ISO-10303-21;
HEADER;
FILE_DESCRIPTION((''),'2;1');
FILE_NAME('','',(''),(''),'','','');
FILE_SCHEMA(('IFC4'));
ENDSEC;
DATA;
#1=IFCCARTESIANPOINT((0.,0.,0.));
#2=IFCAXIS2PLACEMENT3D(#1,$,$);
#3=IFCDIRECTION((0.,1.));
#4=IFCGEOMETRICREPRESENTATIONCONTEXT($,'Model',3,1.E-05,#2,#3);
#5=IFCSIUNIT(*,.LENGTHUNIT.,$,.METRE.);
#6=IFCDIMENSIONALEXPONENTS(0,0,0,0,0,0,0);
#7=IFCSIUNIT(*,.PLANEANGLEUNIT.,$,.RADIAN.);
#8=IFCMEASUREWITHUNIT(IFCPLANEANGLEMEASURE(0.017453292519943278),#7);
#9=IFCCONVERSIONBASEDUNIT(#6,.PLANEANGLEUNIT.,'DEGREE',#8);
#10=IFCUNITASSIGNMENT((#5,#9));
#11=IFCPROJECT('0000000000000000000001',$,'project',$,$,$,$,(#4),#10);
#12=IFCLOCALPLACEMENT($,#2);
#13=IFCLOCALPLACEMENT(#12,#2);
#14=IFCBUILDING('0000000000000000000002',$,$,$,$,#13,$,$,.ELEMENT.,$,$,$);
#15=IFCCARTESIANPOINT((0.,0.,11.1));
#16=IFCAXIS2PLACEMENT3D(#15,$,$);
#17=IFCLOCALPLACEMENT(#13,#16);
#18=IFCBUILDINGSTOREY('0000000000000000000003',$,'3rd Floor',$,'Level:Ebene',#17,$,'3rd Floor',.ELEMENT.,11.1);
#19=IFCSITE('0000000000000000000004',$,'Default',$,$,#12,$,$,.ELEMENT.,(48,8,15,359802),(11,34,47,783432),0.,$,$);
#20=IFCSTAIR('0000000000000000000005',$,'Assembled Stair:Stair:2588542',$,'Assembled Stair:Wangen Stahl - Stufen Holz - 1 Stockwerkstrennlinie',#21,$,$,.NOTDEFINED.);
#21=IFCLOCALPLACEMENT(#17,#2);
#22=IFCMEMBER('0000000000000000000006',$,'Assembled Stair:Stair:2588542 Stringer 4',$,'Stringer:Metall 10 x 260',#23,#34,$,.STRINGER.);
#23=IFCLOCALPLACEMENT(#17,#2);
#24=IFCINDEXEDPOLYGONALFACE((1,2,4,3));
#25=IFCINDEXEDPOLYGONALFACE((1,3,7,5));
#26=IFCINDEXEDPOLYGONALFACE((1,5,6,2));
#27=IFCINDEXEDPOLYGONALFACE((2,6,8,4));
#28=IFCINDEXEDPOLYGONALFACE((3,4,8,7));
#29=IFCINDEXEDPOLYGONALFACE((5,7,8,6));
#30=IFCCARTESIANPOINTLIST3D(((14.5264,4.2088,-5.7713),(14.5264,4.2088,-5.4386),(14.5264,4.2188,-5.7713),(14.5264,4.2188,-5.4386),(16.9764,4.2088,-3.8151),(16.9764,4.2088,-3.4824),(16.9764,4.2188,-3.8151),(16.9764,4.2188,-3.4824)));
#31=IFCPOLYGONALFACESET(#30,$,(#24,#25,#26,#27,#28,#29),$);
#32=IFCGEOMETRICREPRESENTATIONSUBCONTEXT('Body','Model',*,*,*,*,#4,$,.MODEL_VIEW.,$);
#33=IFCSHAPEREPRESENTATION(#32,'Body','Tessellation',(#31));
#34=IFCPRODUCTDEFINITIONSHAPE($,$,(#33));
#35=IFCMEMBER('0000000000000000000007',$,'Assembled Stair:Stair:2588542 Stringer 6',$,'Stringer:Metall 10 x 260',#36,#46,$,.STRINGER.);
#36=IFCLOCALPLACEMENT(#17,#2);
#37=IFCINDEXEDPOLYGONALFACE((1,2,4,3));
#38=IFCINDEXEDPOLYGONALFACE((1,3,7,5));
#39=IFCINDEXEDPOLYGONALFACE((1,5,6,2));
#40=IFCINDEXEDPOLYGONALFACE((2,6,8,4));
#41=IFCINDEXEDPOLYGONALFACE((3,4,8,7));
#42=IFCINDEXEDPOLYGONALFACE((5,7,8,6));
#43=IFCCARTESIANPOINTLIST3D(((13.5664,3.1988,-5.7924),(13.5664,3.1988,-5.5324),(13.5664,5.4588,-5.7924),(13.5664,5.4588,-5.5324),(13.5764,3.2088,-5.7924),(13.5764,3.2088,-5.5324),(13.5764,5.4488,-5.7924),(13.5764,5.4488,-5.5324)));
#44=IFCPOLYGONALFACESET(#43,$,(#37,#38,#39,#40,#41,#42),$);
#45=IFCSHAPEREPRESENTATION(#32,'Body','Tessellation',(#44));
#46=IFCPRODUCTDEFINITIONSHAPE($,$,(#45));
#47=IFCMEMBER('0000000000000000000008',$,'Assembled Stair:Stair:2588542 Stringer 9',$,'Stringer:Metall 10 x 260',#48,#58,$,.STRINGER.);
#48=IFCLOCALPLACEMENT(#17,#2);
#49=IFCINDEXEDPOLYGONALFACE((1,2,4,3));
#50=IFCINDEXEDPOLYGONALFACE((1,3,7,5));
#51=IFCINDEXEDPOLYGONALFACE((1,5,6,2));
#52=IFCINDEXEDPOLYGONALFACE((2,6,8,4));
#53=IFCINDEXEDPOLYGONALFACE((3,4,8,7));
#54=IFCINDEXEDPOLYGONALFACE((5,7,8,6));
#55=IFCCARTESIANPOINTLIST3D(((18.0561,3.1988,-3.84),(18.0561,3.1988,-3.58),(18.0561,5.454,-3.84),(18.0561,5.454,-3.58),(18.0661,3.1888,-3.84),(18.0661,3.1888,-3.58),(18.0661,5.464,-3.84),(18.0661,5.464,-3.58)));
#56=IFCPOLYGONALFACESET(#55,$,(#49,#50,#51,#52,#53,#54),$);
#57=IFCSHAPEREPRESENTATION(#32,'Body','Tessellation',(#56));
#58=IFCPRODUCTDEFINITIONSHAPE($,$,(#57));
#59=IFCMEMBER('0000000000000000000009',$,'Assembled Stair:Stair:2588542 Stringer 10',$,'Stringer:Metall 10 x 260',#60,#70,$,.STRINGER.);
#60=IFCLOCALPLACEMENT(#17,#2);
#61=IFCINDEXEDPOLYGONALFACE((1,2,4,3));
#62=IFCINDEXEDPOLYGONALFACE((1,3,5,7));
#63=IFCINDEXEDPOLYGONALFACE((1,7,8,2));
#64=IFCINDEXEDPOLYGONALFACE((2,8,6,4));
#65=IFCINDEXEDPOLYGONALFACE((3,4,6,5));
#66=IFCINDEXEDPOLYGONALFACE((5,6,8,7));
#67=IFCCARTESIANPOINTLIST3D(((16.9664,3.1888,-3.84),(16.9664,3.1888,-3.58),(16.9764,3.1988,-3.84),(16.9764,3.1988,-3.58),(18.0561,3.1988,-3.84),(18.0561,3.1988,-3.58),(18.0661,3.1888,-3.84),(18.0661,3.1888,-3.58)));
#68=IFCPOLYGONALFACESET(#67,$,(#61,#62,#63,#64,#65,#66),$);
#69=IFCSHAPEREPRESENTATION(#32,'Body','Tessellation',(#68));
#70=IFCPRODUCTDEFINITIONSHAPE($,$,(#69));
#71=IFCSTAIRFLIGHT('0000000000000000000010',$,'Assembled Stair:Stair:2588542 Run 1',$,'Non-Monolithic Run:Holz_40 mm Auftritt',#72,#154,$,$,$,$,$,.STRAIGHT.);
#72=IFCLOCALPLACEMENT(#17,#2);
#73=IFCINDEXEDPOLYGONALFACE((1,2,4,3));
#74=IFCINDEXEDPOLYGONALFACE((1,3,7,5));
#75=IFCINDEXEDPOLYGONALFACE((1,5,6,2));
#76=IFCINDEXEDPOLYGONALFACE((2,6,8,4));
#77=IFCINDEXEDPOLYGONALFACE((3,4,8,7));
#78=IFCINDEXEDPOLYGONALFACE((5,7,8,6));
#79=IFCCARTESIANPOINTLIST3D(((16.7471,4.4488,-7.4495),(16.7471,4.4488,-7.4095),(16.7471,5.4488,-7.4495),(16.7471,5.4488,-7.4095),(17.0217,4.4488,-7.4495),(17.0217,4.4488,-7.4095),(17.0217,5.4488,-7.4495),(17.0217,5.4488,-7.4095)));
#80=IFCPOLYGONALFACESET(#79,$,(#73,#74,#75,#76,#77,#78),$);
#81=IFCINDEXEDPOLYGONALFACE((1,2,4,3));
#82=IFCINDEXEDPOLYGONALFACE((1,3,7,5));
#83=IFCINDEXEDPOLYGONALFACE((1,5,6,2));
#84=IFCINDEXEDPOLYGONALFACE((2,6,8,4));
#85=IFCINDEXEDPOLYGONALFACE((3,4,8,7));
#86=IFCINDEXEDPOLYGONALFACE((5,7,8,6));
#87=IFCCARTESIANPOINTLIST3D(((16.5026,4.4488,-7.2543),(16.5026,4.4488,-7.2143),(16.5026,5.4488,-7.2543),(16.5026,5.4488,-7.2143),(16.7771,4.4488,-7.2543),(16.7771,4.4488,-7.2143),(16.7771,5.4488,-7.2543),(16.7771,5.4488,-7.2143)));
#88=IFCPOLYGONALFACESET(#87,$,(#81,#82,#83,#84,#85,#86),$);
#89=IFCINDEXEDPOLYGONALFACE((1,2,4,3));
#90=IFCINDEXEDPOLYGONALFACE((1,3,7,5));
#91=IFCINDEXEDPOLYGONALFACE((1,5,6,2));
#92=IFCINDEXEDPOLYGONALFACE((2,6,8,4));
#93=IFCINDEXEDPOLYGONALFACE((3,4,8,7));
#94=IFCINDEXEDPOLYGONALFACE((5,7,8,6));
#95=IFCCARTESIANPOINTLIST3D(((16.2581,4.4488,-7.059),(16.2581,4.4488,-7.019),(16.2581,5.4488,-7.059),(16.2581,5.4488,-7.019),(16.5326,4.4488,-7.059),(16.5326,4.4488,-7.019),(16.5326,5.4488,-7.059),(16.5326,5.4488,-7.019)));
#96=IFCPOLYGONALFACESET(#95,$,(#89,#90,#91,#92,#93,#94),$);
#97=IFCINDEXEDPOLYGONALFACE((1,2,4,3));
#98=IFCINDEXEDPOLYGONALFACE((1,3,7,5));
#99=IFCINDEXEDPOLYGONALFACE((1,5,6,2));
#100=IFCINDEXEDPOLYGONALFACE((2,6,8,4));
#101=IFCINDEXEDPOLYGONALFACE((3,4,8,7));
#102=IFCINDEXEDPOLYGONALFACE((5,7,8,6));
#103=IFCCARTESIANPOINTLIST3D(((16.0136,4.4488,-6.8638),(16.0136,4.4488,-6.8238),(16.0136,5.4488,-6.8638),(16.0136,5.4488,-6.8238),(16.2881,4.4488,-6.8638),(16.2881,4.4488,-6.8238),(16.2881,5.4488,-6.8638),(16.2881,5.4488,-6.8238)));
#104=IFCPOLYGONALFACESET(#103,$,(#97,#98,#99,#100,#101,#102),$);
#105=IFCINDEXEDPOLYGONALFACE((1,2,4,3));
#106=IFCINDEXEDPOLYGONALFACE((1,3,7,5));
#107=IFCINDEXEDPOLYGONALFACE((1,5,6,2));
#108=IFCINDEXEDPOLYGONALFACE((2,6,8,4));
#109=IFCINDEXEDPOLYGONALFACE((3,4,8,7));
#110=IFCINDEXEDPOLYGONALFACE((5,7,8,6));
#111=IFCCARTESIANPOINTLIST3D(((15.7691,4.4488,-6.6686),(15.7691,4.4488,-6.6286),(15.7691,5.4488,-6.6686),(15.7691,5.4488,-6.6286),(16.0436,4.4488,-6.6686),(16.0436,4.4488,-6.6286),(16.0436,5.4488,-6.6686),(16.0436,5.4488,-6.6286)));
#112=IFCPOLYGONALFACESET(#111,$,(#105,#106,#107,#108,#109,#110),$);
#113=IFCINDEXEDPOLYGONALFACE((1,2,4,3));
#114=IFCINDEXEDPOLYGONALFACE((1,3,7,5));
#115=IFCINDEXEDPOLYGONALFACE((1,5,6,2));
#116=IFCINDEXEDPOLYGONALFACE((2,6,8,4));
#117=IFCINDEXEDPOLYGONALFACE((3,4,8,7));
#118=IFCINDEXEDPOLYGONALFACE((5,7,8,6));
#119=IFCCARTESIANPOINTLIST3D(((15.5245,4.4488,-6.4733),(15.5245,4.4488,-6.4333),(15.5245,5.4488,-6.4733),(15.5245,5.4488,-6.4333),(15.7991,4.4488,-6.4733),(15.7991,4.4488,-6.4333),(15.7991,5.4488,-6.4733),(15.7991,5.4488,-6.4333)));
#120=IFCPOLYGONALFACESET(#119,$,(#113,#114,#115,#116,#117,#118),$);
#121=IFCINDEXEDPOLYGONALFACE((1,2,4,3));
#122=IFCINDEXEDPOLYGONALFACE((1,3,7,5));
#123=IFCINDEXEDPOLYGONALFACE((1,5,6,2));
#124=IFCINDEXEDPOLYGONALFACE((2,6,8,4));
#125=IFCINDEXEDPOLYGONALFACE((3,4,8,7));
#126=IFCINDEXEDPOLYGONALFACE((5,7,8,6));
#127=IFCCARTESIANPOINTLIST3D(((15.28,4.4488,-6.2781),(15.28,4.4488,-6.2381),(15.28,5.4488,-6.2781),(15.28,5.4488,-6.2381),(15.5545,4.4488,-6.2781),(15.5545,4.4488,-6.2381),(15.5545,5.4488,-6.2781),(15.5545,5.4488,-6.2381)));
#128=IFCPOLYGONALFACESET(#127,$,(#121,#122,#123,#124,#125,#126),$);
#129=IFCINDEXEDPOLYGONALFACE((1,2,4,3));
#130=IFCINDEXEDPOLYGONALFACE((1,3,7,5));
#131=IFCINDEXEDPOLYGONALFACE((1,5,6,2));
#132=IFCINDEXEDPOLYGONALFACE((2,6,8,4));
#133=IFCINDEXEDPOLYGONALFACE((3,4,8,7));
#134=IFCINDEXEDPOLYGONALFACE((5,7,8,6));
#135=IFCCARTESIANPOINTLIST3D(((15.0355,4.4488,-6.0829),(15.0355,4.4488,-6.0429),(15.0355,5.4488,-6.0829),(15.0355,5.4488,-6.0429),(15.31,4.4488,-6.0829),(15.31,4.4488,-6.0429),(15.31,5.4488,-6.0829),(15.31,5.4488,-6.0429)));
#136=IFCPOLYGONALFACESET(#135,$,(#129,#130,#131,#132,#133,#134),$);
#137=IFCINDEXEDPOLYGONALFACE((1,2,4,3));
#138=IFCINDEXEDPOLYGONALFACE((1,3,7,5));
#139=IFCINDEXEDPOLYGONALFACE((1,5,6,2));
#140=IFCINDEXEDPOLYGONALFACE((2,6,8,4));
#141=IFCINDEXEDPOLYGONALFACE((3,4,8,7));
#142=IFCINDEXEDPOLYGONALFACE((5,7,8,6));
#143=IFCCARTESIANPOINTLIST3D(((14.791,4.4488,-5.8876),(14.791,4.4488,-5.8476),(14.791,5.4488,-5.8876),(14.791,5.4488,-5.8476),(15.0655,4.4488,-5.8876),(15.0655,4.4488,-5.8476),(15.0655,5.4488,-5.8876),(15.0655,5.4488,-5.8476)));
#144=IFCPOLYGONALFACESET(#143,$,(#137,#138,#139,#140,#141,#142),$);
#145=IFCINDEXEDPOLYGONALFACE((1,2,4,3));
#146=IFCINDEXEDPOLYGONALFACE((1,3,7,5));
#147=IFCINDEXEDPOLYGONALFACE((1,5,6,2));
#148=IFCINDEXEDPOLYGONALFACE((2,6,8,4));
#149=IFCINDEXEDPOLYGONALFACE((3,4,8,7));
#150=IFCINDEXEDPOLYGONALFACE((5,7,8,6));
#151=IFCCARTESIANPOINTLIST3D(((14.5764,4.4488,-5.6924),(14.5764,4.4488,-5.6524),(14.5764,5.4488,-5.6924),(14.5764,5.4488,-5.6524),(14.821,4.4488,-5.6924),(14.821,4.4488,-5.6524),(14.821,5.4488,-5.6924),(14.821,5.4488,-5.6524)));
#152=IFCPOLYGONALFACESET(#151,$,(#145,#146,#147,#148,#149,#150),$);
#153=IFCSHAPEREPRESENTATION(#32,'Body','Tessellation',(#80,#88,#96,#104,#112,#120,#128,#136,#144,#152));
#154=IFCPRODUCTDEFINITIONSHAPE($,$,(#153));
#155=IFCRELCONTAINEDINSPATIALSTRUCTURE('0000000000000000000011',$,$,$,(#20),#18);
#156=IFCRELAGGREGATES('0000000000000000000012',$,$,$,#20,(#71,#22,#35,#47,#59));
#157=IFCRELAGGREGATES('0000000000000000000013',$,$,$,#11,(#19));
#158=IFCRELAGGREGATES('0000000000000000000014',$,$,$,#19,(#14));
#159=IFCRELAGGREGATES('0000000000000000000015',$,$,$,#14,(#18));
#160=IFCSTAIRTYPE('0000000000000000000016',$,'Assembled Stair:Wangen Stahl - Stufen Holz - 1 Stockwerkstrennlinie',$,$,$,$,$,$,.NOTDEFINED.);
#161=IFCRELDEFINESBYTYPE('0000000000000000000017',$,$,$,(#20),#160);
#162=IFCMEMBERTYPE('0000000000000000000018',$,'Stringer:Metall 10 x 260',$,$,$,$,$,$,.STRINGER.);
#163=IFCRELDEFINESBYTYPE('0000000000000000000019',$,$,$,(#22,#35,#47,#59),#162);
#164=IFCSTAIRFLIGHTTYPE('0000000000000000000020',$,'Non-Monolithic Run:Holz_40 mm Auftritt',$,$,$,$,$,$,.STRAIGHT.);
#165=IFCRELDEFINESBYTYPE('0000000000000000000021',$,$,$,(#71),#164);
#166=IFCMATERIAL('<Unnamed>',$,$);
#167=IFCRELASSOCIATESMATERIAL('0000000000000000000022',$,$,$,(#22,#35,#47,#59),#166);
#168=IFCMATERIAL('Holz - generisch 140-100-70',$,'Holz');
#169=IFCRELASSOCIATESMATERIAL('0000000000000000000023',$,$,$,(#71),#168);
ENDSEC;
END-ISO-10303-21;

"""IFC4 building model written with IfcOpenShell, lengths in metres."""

from ifc_helpers import new_model, entity, si_unit, converted_unit, direction, frame, origin, place, context, subcontext, project, spatial, indexed_curve, outline, extrude, material, type_object, element, aggregate, save


model = new_model("IFC4")

# Units and contexts
model_context = context("Model", 3, precision=1e-05, world=origin(), true_north=direction((0.0, 1.0)))
body_context = subcontext(model_context, "Body", "Model", "MODEL_VIEW")
ifc_project = project(units=[si_unit("LENGTHUNIT", "METRE"), converted_unit("PLANEANGLEUNIT", "DEGREE", entity("IfcPlaneAngleMeasure", 0.017453292519943278), si_unit("PLANEANGLEUNIT", "RADIAN"), dimensions=[0, 0, 0, 0, 0, 0, 0])], contexts=[model_context])

# Site, building, storey
site_placement = place(None, origin())
site = spatial("IfcSite", under=ifc_project, at=site_placement, Name="Default", CompositionType="ELEMENT", RefLatitude=(48, 8, 15, 359802), RefLongitude=(11, 34, 47, 783432), RefElevation=0.0)
building_placement = place(site_placement, origin())
building = spatial("IfcBuilding", under=site, at=building_placement, CompositionType="ELEMENT")
storey_placement = place(building_placement, frame((0.0, 0.0, 11.1)))
storey = spatial("IfcBuildingStorey", under=building, at=storey_placement, Name="3rd Floor", ObjectType="Level:Ebene", LongName="3rd Floor", CompositionType="ELEMENT", Elevation=11.1)

# Shared definitions
stair_type = type_object("IfcStairType", Name="Assembled Stair:Wangen Stahl - Stufen Holz - 1 Stockwerkstrennlinie", PredefinedType="NOTDEFINED")
ifc_material_1 = material(Name="<Unnamed>")
member_type = type_object("IfcMemberType", Name="Stringer:Metall 10 x 260", PredefinedType="STRINGER")

# Stair, members, stair flight
stair_1_placement = place(storey_placement, origin())
stair_1 = element("IfcStair", 1, at=stair_1_placement, inside=storey, type_object=stair_type, Name="Assembled Stair:Stair:2588542", ObjectType="Assembled Stair:Wangen Stahl - Stufen Holz - 1 Stockwerkstrennlinie", PredefinedType="NOTDEFINED")
member_1_placement = place(stair_1_placement, origin())
member_1 = element("IfcMember", 2, at=member_1_placement, type_object=member_type, material=ifc_material_1, Name="Assembled Stair:Stair:2588542 Stringer 4", ObjectType="Stringer:Metall 10 x 260", PredefinedType="STRINGER", context=body_context, shape_type="SweptSolid", body=[
    extrude(outline(indexed_curve([(-1.4638, -0.13), (1.6714, -0.13), (1.4638, 0.13), (-1.6714, 0.13), (-1.4638, -0.13)], self_intersect=False)), frame((15.7514, 4.2088, -4.6269), z_axis=(0.0, 1.0, 0.0), x_axis=(0.781462, 0.0, 0.623952)), (0.0, 0.0, 1.0), 0.01),
])
member_2_placement = place(stair_1_placement, origin())
member_2 = element("IfcMember", 3, at=member_2_placement, type_object=member_type, material=ifc_material_1, Name="Assembled Stair:Stair:2588542 Stringer 6", ObjectType="Stringer:Metall 10 x 260", PredefinedType="STRINGER", context=body_context, shape_type="SweptSolid", body=[
    extrude(outline(indexed_curve([(-1.13, -0.005), (1.13, -0.005), (1.12, 0.005), (-1.12, 0.005), (-1.13, -0.005)], self_intersect=False)), frame((13.5714, 4.3288, -5.7924), z_axis=(0.0, 0.0, 1.0), x_axis=(0.0, -1.0, 0.0)), (0.0, 0.0, 1.0), 0.26),
])
member_3_placement = place(stair_1_placement, origin())
member_3 = element("IfcMember", 4, at=member_3_placement, type_object=member_type, material=ifc_material_1, Name="Assembled Stair:Stair:2588542 Stringer 9", ObjectType="Stringer:Metall 10 x 260", PredefinedType="STRINGER", context=body_context, shape_type="SweptSolid", body=[
    extrude(outline(indexed_curve([(-1.1376, -0.005), (1.1376, -0.005), (1.1276, 0.005), (-1.1276, 0.005), (-1.1376, -0.005)], self_intersect=False)), frame((18.0611, 4.3264, -3.84), z_axis=(0.0, 0.0, 1.0), x_axis=(0.0, 1.0, 0.0)), (0.0, 0.0, 1.0), 0.26),
])
member_4_placement = place(stair_1_placement, origin())
member_4 = element("IfcMember", 5, at=member_4_placement, type_object=member_type, material=ifc_material_1, Name="Assembled Stair:Stair:2588542 Stringer 10", ObjectType="Stringer:Metall 10 x 260", PredefinedType="STRINGER", context=body_context, shape_type="SweptSolid", body=[
    extrude(outline(indexed_curve([(-0.5498, -0.005), (0.5498, -0.005), (0.5398, 0.005), (-0.5398, 0.005), (-0.5498, -0.005)], self_intersect=False)), frame((17.5163, 3.1938, -3.84)), (0.0, 0.0, 1.0), 0.26),
])
ifc_material_2 = material(Name="Holz - generisch 140-100-70", Category="Holz")
stair_flight_type = type_object("IfcStairFlightType", Name="Non-Monolithic Run:Holz_40 mm Auftritt", PredefinedType="STRAIGHT")
stair_flight_1_placement = place(stair_1_placement, origin())
stair_flight_1 = element("IfcStairFlight", 6, at=stair_flight_1_placement, type_object=stair_flight_type, material=ifc_material_2, Name="Assembled Stair:Stair:2588542 Run 1", ObjectType="Non-Monolithic Run:Holz_40 mm Auftritt", PredefinedType="STRAIGHT", context=body_context, shape_type="SweptSolid", body=[
    extrude(outline(indexed_curve([(-0.1373, -0.5), (0.1373, -0.5), (0.1373, 0.5), (-0.1373, 0.5), (-0.1373, -0.5)], self_intersect=False)), frame((16.8844, 4.9488, -7.4495)), (0.0, 0.0, 1.0), 0.04),
    extrude(outline(indexed_curve([(-0.1373, -0.5), (0.1373, -0.5), (0.1373, 0.5), (-0.1373, 0.5), (-0.1373, -0.5)], self_intersect=False)), frame((16.6399, 4.9488, -7.2543)), (0.0, 0.0, 1.0), 0.04),
    extrude(outline(indexed_curve([(-0.1373, -0.5), (0.1373, -0.5), (0.1373, 0.5), (-0.1373, 0.5), (-0.1373, -0.5)], self_intersect=False)), frame((16.3954, 4.9488, -7.059)), (0.0, 0.0, 1.0), 0.04),
    extrude(outline(indexed_curve([(-0.1373, -0.5), (0.1373, -0.5), (0.1373, 0.5), (-0.1373, 0.5), (-0.1373, -0.5)], self_intersect=False)), frame((16.1508, 4.9488, -6.8638)), (0.0, 0.0, 1.0), 0.04),
    extrude(outline(indexed_curve([(-0.1373, -0.5), (0.1373, -0.5), (0.1373, 0.5), (-0.1373, 0.5), (-0.1373, -0.5)], self_intersect=False)), frame((15.9063, 4.9488, -6.6686)), (0.0, 0.0, 1.0), 0.04),
    extrude(outline(indexed_curve([(-0.1373, -0.5), (0.1373, -0.5), (0.1373, 0.5), (-0.1373, 0.5), (-0.1373, -0.5)], self_intersect=False)), frame((15.6618, 4.9488, -6.4733)), (0.0, 0.0, 1.0), 0.04),
    extrude(outline(indexed_curve([(-0.1373, -0.5), (0.1373, -0.5), (0.1373, 0.5), (-0.1373, 0.5), (-0.1373, -0.5)], self_intersect=False)), frame((15.4173, 4.9488, -6.2781)), (0.0, 0.0, 1.0), 0.04),
    extrude(outline(indexed_curve([(-0.1373, -0.5), (0.1373, -0.5), (0.1373, 0.5), (-0.1373, 0.5), (-0.1373, -0.5)], self_intersect=False)), frame((15.1727, 4.9488, -6.0829)), (0.0, 0.0, 1.0), 0.04),
    extrude(outline(indexed_curve([(-0.1373, -0.5), (0.1373, -0.5), (0.1373, 0.5), (-0.1373, 0.5), (-0.1373, -0.5)], self_intersect=False)), frame((14.9282, 4.9488, -5.8876)), (0.0, 0.0, 1.0), 0.04),
    extrude(outline(indexed_curve([(-0.1223, -0.5), (0.1223, -0.5), (0.1223, 0.5), (-0.1223, 0.5), (-0.1223, -0.5)], self_intersect=False)), frame((14.6987, 4.9488, -5.6924)), (0.0, 0.0, 1.0), 0.04),
])
aggregate(stair_1, [stair_flight_1, member_1, member_2, member_3, member_4])

save(model, "model.ifc")
